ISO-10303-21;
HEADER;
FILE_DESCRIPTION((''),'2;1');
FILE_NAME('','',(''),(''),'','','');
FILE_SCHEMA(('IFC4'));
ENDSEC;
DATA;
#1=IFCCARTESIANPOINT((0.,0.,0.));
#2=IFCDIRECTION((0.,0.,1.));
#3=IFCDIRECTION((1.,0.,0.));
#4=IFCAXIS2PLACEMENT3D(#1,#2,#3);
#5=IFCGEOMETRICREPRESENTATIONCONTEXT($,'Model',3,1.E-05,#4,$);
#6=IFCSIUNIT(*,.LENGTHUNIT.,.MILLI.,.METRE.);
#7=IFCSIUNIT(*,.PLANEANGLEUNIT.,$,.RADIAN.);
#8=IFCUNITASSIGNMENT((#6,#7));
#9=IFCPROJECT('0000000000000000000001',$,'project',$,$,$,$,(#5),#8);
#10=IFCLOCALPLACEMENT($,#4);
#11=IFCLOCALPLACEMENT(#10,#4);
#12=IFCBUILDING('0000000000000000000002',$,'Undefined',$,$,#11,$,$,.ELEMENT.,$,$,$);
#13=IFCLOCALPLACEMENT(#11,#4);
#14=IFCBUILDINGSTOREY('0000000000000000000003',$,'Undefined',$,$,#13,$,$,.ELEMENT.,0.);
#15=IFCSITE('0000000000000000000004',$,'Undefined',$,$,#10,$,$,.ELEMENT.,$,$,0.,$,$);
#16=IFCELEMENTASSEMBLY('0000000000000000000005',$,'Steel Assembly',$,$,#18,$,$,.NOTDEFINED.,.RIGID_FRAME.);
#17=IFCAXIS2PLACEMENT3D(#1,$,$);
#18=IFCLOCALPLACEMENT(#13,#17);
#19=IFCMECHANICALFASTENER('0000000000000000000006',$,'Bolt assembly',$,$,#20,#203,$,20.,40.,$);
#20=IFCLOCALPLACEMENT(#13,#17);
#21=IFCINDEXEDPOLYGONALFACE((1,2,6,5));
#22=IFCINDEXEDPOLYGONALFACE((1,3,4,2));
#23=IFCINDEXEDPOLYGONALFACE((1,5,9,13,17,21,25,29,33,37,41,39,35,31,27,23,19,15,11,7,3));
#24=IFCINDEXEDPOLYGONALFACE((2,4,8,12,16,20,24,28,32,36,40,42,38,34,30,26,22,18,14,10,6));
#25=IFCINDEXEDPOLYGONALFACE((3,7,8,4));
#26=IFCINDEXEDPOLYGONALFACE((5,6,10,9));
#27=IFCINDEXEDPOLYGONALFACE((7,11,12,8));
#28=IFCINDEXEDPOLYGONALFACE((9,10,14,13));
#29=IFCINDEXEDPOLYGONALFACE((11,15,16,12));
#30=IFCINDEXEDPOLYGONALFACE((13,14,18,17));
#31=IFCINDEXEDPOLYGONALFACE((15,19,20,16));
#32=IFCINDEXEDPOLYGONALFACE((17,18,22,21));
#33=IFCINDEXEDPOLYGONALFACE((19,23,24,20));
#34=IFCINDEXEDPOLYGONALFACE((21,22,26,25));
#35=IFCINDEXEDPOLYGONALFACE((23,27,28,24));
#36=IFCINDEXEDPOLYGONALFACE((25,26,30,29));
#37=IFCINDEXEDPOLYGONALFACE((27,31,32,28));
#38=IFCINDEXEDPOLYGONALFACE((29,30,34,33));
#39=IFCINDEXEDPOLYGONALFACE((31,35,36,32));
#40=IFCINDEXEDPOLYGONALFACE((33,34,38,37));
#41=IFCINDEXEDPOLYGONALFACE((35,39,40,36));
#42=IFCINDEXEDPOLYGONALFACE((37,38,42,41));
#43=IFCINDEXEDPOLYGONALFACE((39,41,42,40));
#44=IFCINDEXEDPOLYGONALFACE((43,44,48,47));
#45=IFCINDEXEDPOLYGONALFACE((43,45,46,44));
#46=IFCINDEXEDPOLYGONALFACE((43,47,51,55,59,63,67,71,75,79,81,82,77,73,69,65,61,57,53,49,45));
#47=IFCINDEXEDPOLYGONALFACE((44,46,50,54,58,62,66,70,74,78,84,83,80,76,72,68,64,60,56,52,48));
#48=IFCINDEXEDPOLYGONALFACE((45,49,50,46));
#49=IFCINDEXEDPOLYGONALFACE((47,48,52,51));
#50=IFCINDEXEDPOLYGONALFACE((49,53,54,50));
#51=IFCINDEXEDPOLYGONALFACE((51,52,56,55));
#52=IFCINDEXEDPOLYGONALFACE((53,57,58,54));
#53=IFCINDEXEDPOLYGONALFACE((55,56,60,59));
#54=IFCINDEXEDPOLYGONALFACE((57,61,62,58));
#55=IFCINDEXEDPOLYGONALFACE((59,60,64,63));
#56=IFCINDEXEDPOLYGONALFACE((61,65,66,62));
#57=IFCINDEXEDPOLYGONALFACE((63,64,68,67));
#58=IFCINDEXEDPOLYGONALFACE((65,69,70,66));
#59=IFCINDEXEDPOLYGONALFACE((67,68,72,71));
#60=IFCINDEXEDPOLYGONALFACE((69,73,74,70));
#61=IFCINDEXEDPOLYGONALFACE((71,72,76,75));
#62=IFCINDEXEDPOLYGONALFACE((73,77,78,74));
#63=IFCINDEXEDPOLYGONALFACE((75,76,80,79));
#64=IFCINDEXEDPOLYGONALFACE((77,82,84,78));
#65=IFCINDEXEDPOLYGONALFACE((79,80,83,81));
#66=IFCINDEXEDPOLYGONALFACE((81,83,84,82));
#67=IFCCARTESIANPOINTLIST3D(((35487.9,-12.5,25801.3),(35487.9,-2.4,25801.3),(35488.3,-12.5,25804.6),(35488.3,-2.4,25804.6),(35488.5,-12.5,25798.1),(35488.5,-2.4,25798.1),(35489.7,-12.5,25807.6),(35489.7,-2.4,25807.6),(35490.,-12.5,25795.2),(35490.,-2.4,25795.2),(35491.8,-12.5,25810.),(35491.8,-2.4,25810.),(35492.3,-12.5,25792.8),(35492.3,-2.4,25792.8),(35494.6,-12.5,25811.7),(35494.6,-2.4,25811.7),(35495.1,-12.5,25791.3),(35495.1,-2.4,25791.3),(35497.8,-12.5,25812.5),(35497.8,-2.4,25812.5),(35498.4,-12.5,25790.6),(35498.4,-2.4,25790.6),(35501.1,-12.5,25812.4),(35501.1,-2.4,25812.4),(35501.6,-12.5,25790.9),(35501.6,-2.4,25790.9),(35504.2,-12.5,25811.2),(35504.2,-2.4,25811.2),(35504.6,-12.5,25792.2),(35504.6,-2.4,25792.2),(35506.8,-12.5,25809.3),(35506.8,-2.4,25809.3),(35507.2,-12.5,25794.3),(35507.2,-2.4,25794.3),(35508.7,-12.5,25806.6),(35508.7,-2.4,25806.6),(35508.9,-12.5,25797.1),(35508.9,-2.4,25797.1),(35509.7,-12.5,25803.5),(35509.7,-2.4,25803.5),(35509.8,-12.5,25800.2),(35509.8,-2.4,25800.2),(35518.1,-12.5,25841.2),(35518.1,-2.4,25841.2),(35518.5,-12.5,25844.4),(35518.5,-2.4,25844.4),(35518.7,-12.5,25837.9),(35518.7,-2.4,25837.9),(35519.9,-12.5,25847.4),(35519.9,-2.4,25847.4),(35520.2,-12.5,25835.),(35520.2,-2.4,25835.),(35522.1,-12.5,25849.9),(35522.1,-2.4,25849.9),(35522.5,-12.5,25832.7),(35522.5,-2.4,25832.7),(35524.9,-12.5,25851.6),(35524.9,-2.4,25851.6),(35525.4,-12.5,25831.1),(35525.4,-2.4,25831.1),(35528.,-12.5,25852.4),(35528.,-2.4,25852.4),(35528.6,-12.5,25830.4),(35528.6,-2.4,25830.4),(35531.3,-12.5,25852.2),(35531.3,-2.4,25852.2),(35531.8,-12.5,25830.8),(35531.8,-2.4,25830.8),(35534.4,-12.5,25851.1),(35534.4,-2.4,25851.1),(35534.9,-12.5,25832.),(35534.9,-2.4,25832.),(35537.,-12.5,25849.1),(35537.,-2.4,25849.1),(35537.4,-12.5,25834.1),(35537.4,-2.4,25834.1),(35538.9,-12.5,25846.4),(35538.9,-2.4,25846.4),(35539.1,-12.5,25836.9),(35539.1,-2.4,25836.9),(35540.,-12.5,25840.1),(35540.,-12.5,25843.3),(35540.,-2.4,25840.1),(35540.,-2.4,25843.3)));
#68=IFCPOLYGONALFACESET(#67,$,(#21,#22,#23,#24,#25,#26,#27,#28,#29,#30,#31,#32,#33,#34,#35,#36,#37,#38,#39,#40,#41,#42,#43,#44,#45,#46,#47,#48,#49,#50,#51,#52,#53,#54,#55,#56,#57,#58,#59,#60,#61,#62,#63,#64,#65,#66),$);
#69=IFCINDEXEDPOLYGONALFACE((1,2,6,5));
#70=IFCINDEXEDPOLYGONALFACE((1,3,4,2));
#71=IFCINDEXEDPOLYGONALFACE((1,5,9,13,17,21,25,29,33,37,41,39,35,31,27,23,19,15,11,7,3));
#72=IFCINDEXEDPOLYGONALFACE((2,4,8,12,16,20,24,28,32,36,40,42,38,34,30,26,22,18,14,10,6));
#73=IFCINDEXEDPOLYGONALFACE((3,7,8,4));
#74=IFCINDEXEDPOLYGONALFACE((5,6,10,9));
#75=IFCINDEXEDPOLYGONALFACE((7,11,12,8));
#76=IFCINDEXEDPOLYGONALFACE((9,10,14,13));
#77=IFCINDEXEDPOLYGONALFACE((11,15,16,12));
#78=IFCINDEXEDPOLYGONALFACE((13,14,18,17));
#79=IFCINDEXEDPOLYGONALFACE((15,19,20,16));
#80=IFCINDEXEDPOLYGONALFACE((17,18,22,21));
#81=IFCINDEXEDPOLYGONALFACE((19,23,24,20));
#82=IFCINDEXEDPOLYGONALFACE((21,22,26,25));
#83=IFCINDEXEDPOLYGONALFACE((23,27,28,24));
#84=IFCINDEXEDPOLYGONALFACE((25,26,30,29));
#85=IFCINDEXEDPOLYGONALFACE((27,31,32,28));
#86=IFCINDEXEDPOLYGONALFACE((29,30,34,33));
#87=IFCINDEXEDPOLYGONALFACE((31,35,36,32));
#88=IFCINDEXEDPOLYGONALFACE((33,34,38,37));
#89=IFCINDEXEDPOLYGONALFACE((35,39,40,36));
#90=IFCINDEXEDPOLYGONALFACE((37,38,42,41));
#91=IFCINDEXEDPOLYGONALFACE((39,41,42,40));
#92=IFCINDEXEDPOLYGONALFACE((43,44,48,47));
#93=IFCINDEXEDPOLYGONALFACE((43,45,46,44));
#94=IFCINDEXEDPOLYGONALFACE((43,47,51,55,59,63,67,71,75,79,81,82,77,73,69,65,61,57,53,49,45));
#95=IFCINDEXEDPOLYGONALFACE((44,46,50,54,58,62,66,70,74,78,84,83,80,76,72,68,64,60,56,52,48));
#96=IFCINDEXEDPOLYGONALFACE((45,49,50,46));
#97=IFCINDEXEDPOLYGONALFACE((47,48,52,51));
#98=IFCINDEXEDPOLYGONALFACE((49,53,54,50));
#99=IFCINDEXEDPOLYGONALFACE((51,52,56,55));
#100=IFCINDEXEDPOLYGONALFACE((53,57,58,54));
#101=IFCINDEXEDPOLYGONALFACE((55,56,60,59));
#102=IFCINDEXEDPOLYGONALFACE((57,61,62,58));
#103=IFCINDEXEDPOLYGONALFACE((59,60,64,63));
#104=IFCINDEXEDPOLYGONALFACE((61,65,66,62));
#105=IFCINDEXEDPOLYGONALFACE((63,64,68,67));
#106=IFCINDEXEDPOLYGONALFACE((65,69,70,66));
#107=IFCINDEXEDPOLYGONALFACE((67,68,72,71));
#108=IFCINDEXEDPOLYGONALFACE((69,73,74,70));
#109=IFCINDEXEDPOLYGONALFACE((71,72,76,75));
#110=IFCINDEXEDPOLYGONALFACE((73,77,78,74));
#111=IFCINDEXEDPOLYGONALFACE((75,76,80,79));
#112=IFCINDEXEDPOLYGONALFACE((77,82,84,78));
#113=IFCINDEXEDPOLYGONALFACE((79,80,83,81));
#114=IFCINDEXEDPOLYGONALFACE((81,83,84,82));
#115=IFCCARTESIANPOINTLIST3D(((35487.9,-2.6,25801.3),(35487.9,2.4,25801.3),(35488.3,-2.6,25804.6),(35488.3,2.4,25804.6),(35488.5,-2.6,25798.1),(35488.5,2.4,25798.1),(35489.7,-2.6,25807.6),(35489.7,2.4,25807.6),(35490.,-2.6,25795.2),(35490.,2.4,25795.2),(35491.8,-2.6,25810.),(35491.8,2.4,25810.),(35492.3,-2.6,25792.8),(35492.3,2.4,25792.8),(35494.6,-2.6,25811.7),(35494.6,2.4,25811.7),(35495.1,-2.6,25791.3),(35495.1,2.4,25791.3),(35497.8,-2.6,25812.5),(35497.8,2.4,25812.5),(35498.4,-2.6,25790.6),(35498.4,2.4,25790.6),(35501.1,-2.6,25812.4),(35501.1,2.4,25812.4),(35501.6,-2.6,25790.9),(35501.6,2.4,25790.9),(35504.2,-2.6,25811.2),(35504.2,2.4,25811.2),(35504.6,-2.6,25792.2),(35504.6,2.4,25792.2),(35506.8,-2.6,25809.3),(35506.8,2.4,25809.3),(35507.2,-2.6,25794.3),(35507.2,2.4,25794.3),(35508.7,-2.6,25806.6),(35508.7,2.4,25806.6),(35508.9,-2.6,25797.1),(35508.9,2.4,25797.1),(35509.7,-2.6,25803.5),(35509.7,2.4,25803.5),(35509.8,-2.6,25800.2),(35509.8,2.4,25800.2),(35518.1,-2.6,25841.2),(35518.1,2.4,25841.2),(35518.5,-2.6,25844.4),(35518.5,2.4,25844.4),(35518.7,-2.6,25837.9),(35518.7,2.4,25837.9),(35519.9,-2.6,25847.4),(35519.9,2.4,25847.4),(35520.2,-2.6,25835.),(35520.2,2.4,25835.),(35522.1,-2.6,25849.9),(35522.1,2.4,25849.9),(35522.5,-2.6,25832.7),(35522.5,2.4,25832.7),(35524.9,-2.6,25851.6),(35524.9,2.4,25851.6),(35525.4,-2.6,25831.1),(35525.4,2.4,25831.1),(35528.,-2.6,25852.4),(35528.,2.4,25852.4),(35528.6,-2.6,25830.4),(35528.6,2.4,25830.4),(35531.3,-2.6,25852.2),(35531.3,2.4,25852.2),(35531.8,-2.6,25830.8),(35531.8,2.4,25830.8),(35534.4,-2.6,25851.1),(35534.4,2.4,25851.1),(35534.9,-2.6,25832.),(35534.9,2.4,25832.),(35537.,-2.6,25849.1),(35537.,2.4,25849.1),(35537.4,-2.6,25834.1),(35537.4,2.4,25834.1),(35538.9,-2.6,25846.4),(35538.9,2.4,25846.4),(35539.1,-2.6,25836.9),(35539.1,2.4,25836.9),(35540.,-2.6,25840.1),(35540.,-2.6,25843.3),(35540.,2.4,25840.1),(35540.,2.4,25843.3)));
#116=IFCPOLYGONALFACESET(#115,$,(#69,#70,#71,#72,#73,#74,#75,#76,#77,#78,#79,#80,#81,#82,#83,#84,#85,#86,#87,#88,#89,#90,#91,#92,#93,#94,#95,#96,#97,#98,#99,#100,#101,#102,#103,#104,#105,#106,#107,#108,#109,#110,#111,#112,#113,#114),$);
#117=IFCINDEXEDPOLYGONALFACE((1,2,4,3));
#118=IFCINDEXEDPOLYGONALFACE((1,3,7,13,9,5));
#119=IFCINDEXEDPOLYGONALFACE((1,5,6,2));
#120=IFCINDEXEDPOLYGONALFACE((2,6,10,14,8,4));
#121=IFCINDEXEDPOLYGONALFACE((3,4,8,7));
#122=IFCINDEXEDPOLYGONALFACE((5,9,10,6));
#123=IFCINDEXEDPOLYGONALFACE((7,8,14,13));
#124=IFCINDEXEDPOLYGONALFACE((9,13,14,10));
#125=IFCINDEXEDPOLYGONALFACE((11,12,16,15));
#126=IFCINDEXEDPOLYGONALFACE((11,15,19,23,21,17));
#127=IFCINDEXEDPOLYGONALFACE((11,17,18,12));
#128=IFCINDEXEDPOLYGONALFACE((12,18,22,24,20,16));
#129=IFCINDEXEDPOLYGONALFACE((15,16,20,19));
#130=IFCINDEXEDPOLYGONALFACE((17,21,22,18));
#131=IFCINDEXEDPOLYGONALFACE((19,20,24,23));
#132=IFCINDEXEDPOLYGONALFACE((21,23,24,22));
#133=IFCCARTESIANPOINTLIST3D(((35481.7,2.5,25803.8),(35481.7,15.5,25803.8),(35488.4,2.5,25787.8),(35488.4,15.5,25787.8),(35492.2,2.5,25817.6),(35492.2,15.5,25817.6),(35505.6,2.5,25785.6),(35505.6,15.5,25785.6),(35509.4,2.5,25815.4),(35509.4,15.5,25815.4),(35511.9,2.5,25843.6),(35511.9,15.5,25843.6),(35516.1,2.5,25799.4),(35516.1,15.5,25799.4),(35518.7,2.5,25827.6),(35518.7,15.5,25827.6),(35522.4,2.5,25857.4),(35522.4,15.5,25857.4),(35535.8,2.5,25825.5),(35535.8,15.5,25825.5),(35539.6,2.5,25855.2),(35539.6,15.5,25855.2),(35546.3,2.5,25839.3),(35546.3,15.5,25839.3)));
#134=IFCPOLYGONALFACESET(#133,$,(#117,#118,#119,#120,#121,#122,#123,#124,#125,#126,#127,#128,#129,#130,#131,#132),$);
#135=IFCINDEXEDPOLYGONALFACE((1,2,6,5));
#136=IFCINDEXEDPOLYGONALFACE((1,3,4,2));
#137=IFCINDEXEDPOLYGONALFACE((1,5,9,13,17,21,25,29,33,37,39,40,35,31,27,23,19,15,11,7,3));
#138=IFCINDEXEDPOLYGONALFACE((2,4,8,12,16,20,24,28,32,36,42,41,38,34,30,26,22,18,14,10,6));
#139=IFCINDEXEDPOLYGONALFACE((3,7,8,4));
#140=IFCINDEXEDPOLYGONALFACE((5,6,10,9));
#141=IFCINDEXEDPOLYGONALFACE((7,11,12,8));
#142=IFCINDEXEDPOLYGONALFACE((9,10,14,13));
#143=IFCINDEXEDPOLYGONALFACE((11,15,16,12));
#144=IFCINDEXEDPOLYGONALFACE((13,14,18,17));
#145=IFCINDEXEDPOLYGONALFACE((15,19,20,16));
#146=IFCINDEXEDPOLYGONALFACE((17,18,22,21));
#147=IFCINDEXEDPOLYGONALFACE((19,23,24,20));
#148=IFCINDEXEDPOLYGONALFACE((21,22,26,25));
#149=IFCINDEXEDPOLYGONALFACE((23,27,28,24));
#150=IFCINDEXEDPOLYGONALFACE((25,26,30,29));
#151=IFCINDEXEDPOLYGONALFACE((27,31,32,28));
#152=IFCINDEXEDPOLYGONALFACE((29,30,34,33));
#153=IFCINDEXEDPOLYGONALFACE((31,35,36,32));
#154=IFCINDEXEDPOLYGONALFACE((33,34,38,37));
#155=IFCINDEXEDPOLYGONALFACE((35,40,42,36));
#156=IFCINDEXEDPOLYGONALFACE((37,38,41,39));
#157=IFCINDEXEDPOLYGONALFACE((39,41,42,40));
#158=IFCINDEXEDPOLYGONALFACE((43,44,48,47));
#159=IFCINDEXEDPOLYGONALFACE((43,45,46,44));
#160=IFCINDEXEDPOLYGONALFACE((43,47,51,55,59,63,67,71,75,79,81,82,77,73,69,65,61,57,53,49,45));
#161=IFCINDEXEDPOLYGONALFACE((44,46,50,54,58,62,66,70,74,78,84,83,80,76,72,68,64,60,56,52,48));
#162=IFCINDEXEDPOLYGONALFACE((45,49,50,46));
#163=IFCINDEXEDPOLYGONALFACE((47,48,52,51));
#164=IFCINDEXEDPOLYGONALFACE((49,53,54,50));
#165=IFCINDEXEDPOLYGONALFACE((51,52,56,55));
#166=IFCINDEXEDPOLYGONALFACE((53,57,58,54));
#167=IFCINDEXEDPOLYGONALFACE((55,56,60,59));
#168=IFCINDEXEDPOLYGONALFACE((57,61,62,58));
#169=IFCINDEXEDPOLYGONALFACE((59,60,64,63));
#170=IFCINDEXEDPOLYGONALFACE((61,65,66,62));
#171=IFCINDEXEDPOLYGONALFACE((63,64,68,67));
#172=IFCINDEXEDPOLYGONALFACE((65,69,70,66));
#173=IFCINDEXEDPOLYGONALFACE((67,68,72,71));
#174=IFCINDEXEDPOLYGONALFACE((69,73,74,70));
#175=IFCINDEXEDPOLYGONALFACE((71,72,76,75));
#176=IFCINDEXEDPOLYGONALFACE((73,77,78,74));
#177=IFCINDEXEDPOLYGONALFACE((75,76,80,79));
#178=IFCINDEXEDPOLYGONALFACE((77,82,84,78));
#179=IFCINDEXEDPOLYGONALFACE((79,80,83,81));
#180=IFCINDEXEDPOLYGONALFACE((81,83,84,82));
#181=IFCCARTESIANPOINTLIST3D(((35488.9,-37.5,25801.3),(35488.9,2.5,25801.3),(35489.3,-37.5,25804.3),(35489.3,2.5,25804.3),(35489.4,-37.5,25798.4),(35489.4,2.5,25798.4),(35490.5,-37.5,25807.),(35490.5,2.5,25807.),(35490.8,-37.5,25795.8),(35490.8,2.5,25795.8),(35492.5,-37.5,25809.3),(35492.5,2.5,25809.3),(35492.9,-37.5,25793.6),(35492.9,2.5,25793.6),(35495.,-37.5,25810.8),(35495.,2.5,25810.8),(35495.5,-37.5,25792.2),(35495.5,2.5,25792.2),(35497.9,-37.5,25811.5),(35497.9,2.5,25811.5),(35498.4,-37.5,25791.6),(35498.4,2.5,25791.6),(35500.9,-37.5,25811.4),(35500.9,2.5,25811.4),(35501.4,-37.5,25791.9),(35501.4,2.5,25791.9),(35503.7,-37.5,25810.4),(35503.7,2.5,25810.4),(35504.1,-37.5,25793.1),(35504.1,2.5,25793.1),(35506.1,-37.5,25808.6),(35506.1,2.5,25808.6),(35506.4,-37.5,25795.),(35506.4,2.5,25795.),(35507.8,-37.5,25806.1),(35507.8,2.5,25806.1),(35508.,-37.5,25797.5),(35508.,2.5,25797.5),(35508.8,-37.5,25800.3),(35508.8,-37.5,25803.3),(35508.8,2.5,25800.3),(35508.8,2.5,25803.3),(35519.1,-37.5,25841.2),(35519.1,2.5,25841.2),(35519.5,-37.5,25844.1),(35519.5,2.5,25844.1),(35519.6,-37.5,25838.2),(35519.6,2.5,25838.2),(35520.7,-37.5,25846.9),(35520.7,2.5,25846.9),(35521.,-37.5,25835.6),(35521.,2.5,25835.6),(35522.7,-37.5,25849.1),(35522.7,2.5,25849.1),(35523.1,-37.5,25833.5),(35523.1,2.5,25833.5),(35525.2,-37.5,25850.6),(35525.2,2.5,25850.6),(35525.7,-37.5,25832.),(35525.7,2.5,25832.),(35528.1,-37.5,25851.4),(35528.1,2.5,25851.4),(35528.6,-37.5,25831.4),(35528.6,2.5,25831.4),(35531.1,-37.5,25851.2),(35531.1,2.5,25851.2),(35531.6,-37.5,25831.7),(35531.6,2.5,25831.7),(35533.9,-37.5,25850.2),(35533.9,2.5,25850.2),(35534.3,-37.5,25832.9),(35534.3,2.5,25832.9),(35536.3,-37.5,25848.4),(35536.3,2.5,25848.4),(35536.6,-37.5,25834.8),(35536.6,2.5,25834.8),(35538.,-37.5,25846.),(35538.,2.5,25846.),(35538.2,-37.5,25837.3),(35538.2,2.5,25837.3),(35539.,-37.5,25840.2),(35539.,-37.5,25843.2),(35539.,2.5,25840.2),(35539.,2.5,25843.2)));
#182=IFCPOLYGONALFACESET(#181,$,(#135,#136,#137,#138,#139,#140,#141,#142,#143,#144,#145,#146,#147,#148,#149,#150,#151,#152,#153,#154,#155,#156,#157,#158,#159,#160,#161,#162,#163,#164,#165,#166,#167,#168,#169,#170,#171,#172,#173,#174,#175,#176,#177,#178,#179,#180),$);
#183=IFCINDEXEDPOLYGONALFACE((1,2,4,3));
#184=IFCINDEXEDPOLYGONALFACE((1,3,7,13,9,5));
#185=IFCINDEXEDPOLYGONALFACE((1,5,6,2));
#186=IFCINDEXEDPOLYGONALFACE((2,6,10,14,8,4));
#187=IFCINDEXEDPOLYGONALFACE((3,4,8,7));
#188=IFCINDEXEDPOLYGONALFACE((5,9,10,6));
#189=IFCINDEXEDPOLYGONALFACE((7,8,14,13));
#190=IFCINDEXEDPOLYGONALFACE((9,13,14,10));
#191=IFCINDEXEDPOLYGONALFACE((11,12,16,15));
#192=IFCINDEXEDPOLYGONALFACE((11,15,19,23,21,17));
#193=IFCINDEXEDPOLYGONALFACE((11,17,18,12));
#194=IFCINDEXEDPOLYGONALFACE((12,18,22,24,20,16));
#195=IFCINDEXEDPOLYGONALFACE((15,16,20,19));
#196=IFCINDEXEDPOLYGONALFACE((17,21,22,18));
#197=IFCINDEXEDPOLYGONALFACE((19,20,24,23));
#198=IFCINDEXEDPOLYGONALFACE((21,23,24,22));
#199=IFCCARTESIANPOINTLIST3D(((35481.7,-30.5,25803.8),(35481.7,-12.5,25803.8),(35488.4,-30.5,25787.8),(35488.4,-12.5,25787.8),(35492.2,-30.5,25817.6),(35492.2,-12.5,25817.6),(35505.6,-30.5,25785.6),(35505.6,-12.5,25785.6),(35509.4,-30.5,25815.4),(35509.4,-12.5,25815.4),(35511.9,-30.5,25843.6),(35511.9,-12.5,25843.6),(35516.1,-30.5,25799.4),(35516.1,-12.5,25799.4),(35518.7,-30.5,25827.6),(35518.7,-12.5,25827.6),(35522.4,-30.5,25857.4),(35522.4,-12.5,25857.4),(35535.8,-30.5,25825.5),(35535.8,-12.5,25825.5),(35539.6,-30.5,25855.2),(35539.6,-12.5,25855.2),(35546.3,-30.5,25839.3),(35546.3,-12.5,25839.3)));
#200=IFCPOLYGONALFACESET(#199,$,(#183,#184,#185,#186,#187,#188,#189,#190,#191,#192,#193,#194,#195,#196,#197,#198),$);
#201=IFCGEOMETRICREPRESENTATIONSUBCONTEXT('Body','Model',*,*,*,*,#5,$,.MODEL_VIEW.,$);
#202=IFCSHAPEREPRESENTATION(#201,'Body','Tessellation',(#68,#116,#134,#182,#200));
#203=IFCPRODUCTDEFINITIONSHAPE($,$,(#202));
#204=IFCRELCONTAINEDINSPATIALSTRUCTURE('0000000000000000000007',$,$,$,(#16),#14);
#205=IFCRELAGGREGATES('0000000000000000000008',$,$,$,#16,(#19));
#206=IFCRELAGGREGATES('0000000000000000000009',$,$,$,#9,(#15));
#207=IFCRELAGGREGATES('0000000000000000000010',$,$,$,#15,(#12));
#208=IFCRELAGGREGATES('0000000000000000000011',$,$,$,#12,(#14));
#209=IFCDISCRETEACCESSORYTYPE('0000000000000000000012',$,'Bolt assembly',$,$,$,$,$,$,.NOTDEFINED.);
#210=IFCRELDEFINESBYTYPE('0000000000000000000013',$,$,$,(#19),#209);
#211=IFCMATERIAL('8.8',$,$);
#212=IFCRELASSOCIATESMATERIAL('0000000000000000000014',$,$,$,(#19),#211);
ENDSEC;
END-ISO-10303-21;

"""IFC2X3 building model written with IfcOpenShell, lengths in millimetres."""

from ifc_helpers import new_model, si_unit, frame, origin_with_axes, origin_2d_with_axis, place, context, subcontext, project, spatial, polyline, circle, outline, extrude, source, transform, mapped, material, type_object, element, aggregate, save


model = new_model("IFC2X3")

# Units and contexts
model_context = context("Model", 3, precision=1e-05, world=origin_with_axes())
body_context = subcontext(model_context, "Body", "Model", "MODEL_VIEW")
ifc_project = project(units=[si_unit("LENGTHUNIT", "METRE", prefix="MILLI"), si_unit("PLANEANGLEUNIT", "RADIAN")], contexts=[model_context])

# Site, building, storey
site_placement = place(None, origin_with_axes())
site = spatial("IfcSite", under=ifc_project, at=site_placement, Name="Undefined", CompositionType="ELEMENT", RefElevation=0.0)
building_placement = place(site_placement, origin_with_axes())
building = spatial("IfcBuilding", under=site, at=building_placement, Name="Undefined", CompositionType="ELEMENT")
storey_placement = place(building_placement, origin_with_axes())
storey = spatial("IfcBuildingStorey", under=building, at=storey_placement, Name="Undefined", CompositionType="ELEMENT", Elevation=0.0)

# Element assembly
assembly_1_placement = place(storey_placement, origin_with_axes())
assembly_1 = element("IfcElementAssembly", 1, at=assembly_1_placement, inside=storey, Name="Steel Assembly", AssemblyPlace="NOTDEFINED", PredefinedType="RIGID_FRAME")

# Shared definitions
discrete_accessory_type_1 = type_object("IfcDiscreteAccessoryType", Name="Bolt assembly")
ifc_material_1 = material(Name="8.8")

# Mechanical fastener
shared_shape_1 = source(origin_with_axes(), body_context, "Body", "SweptSolid", [
    extrude(circle(Radius=11.0, at=origin_2d_with_axis()), frame((0.0, 2.4, 0.0), z_axis=(0.0, 1.0, 0.0), x_axis=(1.0, 0.0, 0.0)), (0.0, 0.0, 1.0), 10.1),
    extrude(circle(Radius=11.0, at=origin_2d_with_axis()), frame((0.0, -2.4, 0.0), z_axis=(0.0, 1.0, 0.0), x_axis=(1.0, 0.0, 0.0)), (0.0, 0.0, 1.0), 5.0),
    extrude(outline(polyline([(17.3, 0.0), (8.7, 15.0), (-8.7, 15.0), (-17.3, 0.0), (-8.7, -15.0), (8.7, -15.0), (17.3, 0.0)])), frame((0.0, -15.5, 0.0), z_axis=(0.0, 1.0, 0.0), x_axis=(1.0, 0.0, 0.0)), (0.0, 0.0, 1.0), 13.0),
    extrude(circle(Radius=10.0, at=origin_2d_with_axis()), frame((0.0, -2.5, 0.0), z_axis=(0.0, 1.0, 0.0), x_axis=(1.0, 0.0, 0.0)), (0.0, 0.0, 1.0), 40.0),
    extrude(outline(polyline([(17.3, 0.0), (8.7, 15.0), (-8.7, 15.0), (-17.3, 0.0), (-8.7, -15.0), (8.7, -15.0), (17.3, 0.0)])), frame((0.0, 12.5, 0.0), z_axis=(0.0, 1.0, 0.0), x_axis=(1.0, 0.0, 0.0)), (0.0, 0.0, 1.0), 18.0),
])
mechanical_fastener_1_placement = place(assembly_1_placement, frame((35529.1, 0.0, 25841.4), z_axis=(-0.796808, 0.0, 0.604233), x_axis=(-0.604233, 0.0, -0.796808)))
mechanical_fastener_1 = element("IfcMechanicalFastener", 2, at=mechanical_fastener_1_placement, type_object=discrete_accessory_type_1, material=ifc_material_1, Name="Bolt assembly", NominalDiameter=20.0, NominalLength=40.0, context=body_context, shape_type="MappedRepresentation", body=[
    mapped(shared_shape_1, transform((0.0, 0.0, 0.0))),
    mapped(shared_shape_1, transform((50.0, 0.0, 0.0))),
])
aggregate(assembly_1, [mechanical_fastener_1])

save(model, "model.ifc")
